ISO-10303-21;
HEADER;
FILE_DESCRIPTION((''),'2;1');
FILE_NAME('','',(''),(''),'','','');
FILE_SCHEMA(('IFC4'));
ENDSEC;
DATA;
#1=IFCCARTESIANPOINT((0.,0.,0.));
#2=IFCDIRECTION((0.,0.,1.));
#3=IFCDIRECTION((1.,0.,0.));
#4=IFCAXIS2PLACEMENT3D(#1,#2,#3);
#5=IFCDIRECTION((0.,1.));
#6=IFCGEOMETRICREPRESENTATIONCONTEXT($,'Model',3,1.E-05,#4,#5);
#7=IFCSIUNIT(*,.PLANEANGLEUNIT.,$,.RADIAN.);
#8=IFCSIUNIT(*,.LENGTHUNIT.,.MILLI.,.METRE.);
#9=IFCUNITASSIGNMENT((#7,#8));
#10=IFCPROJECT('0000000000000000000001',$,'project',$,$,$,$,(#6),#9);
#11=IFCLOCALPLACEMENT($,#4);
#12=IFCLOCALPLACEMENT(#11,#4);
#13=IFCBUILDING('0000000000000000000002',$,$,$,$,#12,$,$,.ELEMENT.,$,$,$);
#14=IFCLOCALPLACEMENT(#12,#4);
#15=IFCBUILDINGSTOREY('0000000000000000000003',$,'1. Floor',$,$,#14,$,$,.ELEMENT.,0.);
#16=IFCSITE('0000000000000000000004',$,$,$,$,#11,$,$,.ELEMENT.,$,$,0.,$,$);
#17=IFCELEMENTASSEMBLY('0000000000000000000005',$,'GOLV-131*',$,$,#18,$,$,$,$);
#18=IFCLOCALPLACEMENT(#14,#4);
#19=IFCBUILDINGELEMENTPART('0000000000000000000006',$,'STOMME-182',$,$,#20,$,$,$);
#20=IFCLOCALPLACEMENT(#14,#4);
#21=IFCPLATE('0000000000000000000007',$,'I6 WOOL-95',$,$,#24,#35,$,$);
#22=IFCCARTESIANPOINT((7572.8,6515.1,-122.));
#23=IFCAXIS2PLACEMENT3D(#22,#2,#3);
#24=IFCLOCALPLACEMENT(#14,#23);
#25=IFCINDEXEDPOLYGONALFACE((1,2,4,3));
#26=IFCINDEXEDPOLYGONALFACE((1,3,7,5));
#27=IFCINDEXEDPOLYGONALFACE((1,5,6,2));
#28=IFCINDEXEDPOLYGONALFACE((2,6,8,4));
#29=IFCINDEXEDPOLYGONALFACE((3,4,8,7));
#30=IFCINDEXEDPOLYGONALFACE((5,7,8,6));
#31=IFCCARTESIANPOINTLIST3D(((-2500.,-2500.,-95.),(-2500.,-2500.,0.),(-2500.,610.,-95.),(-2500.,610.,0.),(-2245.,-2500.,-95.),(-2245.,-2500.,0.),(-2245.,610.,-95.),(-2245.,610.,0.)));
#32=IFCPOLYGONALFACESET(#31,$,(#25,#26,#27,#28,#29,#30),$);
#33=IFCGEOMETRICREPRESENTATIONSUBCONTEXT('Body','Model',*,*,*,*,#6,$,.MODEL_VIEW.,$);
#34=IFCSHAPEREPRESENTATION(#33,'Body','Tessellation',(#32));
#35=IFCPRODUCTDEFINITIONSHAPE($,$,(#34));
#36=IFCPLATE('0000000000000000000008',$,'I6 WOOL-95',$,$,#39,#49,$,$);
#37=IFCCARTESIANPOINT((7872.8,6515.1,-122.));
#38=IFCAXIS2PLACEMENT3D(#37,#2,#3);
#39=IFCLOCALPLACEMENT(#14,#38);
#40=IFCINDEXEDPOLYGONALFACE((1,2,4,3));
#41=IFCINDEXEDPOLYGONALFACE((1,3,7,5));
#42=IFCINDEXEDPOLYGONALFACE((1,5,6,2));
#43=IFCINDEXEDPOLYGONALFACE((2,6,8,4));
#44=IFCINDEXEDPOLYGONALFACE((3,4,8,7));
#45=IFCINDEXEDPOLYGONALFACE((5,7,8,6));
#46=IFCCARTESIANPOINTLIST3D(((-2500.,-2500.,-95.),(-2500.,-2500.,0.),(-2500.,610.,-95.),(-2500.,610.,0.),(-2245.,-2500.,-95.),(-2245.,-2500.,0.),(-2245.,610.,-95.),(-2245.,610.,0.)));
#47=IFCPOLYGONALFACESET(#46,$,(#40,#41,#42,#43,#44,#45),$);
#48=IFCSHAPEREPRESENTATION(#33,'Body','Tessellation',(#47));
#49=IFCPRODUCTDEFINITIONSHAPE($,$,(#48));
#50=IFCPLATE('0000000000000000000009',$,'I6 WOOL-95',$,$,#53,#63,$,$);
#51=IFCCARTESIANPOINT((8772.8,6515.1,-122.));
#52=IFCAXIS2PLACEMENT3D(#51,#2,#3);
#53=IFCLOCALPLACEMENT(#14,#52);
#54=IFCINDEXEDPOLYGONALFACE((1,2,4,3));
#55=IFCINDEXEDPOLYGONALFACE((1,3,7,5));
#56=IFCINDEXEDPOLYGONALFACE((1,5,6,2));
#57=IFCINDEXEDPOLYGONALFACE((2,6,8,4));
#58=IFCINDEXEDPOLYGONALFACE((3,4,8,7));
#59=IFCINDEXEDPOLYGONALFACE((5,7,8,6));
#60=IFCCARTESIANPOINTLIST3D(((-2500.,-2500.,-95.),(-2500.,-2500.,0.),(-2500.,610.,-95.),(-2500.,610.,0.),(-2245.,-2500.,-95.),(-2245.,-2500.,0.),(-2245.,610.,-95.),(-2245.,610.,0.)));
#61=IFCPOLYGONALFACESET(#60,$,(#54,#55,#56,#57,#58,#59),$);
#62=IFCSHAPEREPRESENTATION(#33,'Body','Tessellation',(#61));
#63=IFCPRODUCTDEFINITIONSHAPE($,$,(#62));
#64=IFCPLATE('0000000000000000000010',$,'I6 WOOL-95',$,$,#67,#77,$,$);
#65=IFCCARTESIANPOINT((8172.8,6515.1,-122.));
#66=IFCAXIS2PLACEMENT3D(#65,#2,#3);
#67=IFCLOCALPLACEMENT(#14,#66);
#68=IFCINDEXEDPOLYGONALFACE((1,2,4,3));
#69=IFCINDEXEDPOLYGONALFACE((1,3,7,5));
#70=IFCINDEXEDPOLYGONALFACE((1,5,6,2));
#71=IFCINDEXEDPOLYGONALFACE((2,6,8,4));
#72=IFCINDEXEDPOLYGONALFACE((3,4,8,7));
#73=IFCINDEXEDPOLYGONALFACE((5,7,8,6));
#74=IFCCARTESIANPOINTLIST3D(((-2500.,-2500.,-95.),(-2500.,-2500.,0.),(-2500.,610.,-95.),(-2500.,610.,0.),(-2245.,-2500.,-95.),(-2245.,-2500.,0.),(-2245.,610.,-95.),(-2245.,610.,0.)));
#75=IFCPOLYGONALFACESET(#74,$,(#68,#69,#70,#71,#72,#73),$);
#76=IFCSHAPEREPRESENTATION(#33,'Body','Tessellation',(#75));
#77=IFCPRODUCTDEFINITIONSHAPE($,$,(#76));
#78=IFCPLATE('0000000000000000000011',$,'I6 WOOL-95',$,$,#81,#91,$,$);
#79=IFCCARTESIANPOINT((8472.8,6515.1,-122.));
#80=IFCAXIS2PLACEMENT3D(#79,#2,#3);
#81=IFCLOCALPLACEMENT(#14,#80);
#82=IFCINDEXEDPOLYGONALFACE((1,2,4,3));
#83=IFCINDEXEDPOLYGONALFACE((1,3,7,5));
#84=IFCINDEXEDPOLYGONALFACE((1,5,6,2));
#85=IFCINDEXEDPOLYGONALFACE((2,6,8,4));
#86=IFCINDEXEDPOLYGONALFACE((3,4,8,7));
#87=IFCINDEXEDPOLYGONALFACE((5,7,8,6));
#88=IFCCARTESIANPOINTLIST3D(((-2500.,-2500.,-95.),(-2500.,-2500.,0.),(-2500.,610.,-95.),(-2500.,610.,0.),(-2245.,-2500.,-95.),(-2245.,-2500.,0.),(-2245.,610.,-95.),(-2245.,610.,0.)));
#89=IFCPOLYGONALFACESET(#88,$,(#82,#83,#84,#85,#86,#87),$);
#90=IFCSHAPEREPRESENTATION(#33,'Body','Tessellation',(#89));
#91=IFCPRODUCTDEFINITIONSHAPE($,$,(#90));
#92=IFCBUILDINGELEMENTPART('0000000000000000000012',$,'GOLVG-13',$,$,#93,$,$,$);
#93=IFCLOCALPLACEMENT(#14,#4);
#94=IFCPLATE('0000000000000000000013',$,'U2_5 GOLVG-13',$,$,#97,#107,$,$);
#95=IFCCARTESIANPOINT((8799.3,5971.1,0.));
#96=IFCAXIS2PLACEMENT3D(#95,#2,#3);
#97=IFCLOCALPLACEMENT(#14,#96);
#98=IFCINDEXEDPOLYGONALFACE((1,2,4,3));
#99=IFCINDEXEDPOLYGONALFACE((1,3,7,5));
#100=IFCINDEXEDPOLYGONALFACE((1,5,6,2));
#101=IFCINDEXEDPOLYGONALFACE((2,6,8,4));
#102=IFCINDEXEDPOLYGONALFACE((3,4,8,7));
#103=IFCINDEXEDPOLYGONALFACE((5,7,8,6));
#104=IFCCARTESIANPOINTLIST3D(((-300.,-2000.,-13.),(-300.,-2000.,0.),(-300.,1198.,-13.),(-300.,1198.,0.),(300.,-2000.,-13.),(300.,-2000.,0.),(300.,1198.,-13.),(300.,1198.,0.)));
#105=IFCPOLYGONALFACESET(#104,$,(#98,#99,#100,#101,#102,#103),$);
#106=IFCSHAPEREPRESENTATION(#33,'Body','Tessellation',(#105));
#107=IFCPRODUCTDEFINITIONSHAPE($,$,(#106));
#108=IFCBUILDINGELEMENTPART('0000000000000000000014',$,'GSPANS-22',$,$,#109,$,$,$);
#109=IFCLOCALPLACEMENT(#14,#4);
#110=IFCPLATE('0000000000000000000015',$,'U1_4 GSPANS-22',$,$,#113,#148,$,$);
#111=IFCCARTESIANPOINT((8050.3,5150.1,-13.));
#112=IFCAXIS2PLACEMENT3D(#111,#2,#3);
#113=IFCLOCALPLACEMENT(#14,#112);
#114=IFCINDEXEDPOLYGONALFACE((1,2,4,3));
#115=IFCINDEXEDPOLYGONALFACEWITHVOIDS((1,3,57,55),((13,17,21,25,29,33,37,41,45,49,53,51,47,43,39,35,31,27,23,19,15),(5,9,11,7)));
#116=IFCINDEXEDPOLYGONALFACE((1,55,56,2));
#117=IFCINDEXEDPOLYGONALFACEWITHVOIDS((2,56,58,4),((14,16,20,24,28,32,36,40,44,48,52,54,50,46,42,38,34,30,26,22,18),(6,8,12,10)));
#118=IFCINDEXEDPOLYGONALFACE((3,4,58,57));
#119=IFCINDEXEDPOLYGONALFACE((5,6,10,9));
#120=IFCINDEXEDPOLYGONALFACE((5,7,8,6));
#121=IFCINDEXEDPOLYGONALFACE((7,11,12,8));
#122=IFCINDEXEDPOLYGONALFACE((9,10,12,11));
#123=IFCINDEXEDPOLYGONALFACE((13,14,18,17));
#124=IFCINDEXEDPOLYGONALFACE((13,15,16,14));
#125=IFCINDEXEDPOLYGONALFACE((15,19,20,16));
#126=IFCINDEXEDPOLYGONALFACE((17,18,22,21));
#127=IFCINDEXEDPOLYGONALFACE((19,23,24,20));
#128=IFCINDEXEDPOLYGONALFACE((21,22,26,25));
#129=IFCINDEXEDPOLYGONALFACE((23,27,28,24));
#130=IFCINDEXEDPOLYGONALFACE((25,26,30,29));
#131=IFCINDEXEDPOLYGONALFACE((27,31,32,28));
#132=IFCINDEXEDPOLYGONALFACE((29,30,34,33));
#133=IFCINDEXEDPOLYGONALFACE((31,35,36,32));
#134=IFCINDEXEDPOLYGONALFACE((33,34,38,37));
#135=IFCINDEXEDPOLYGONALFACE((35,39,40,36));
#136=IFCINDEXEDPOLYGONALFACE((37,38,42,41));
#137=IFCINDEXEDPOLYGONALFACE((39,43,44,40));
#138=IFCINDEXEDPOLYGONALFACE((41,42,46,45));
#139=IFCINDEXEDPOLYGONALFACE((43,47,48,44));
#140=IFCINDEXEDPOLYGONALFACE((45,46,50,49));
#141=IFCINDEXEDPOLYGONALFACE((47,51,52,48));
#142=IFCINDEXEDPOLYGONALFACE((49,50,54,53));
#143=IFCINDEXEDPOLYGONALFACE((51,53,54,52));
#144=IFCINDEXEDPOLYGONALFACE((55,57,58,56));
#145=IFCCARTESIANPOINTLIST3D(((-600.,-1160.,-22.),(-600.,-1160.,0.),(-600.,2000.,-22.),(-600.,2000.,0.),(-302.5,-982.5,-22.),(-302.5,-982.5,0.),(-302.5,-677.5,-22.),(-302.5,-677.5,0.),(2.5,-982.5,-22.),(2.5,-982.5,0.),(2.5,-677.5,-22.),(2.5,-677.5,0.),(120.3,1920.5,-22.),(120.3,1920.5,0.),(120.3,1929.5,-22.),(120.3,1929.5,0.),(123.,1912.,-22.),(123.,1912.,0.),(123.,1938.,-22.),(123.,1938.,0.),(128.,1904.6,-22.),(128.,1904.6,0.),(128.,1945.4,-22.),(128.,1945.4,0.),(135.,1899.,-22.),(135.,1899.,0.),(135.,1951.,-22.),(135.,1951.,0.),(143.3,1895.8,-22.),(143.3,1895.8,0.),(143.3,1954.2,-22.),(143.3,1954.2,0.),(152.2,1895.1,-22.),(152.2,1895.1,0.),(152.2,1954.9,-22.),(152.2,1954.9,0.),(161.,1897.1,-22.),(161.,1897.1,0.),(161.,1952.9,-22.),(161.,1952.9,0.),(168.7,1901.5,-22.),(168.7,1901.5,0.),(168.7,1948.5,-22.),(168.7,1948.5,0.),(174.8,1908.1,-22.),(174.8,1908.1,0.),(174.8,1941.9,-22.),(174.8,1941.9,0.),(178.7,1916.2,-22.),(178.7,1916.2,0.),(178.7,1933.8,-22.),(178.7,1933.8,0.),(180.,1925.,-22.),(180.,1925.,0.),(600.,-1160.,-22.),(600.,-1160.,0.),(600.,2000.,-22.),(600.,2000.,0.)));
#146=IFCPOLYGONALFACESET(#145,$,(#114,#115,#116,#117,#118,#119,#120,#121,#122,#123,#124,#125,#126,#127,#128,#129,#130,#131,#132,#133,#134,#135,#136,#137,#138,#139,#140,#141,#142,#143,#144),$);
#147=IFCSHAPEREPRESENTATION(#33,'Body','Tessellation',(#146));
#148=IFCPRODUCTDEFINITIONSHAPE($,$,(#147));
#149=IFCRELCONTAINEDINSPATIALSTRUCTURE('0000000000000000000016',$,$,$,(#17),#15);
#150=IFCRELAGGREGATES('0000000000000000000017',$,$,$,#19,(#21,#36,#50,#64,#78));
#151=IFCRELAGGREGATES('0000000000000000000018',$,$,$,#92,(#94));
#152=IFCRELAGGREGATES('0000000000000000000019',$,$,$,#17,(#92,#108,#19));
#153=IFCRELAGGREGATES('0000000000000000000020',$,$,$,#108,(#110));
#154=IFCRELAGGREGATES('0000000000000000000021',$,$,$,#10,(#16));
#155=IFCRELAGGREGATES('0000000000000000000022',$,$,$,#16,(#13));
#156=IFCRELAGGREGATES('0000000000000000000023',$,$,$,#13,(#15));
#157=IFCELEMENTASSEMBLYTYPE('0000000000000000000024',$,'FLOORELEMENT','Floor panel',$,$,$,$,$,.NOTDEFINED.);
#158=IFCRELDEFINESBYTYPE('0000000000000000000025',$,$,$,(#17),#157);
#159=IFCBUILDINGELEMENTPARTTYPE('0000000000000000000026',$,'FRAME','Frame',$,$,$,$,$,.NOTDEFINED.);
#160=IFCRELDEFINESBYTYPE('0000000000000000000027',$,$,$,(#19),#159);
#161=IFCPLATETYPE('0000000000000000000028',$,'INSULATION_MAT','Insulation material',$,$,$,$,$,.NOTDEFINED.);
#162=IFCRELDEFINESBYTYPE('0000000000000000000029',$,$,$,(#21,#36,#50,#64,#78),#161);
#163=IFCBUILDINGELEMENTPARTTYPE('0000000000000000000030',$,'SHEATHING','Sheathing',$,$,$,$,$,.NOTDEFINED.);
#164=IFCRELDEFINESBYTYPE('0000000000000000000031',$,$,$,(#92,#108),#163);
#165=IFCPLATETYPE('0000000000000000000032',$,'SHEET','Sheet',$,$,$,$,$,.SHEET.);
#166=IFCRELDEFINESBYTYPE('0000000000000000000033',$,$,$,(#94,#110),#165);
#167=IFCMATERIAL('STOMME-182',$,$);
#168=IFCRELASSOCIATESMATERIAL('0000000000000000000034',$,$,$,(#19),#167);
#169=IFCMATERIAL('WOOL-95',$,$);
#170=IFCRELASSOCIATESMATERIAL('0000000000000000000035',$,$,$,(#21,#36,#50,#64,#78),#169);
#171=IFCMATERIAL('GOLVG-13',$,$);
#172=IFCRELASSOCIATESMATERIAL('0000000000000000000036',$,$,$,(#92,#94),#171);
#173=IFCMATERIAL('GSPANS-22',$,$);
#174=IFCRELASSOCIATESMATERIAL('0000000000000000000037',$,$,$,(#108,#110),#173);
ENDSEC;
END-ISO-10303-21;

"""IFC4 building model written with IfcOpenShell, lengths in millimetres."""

from ifc_helpers import new_model, si_unit, direction, frame, origin_with_axes, origin_2d_with_axis, place, context, subcontext, project, spatial, rectangle, circle, extrude, boolean, material, type_object, element, aggregate, save


model = new_model("IFC4")

# Units and contexts
model_context = context("Model", 3, precision=1e-05, world=origin_with_axes(), true_north=direction((0.0, 1.0)))
body_context = subcontext(model_context, "Body", "Model", "MODEL_VIEW")
ifc_project = project(units=[si_unit("PLANEANGLEUNIT", "RADIAN"), si_unit("LENGTHUNIT", "METRE", prefix="MILLI")], contexts=[model_context])

# Site, building, storey
site_placement = place(None, origin_with_axes())
site = spatial("IfcSite", under=ifc_project, at=site_placement, CompositionType="ELEMENT", RefElevation=0.0)
building_placement = place(site_placement, origin_with_axes())
building = spatial("IfcBuilding", under=site, at=building_placement, CompositionType="ELEMENT")
storey_placement = place(building_placement, origin_with_axes())
storey = spatial("IfcBuildingStorey", under=building, at=storey_placement, Name="1. Floor", CompositionType="ELEMENT", Elevation=0.0)

# Element assembly, building element part, plates
element_assembly_type_1 = type_object("IfcElementAssemblyType", Name="FLOORELEMENT", Description="Floor panel", PredefinedType="NOTDEFINED")
assembly_1_placement = place(storey_placement, origin_with_axes())
assembly_1 = element("IfcElementAssembly", 1, at=assembly_1_placement, inside=storey, type_object=element_assembly_type_1, Name="GOLV-131*")
ifc_material_1 = material(Name="STOMME-182")
building_element_part_type_1 = type_object("IfcBuildingElementPartType", Name="FRAME", Description="Frame", PredefinedType="NOTDEFINED")
building_element_part_1_placement = place(storey_placement, origin_with_axes())
building_element_part_1 = element("IfcBuildingElementPart", 2, at=building_element_part_1_placement, type_object=building_element_part_type_1, material=ifc_material_1, Name="STOMME-182")
ifc_material_2 = material(Name="WOOL-95")
plate_type_1 = type_object("IfcPlateType", Name="INSULATION_MAT", Description="Insulation material", PredefinedType="NOTDEFINED")
plate_1_placement = place(storey_placement, frame((7572.8, 6515.1, -122.0), z_axis=(0.0, 0.0, 1.0), x_axis=(1.0, 0.0, 0.0)))
plate_1 = element("IfcPlate", 3, at=plate_1_placement, type_object=plate_type_1, material=ifc_material_2, Name="I6 WOOL-95", context=body_context, shape_type="SweptSolid", body=[
    extrude(rectangle(XDim=95.0, YDim=255.0, at=origin_2d_with_axis()), frame((-2372.5, -2500.0, -47.5), z_axis=(0.0, 1.0, 0.0), x_axis=(0.0, 0.0, 1.0)), (0.0, 0.0, 1.0), 3110.0),
])
plate_2_placement = place(storey_placement, frame((7872.8, 6515.1, -122.0), z_axis=(0.0, 0.0, 1.0), x_axis=(1.0, 0.0, 0.0)))
plate_2 = element("IfcPlate", 4, at=plate_2_placement, type_object=plate_type_1, material=ifc_material_2, Name="I6 WOOL-95", context=body_context, shape_type="SweptSolid", body=[
    extrude(rectangle(XDim=95.0, YDim=255.0, at=origin_2d_with_axis()), frame((-2372.5, -2500.0, -47.5), z_axis=(0.0, 1.0, 0.0), x_axis=(0.0, 0.0, 1.0)), (0.0, 0.0, 1.0), 3110.0),
])
plate_3_placement = place(storey_placement, frame((8772.8, 6515.1, -122.0), z_axis=(0.0, 0.0, 1.0), x_axis=(1.0, 0.0, 0.0)))
plate_3 = element("IfcPlate", 5, at=plate_3_placement, type_object=plate_type_1, material=ifc_material_2, Name="I6 WOOL-95", context=body_context, shape_type="SweptSolid", body=[
    extrude(rectangle(XDim=95.0, YDim=255.0, at=origin_2d_with_axis()), frame((-2372.5, -2500.0, -47.5), z_axis=(0.0, 1.0, 0.0), x_axis=(0.0, 0.0, 1.0)), (0.0, 0.0, 1.0), 3110.0),
])
plate_4_placement = place(storey_placement, frame((8172.8, 6515.1, -122.0), z_axis=(0.0, 0.0, 1.0), x_axis=(1.0, 0.0, 0.0)))
plate_4 = element("IfcPlate", 6, at=plate_4_placement, type_object=plate_type_1, material=ifc_material_2, Name="I6 WOOL-95", context=body_context, shape_type="SweptSolid", body=[
    extrude(rectangle(XDim=95.0, YDim=255.0, at=origin_2d_with_axis()), frame((-2372.5, -2500.0, -47.5), z_axis=(0.0, 1.0, 0.0), x_axis=(0.0, 0.0, 1.0)), (0.0, 0.0, 1.0), 3110.0),
])
plate_5_placement = place(storey_placement, frame((8472.8, 6515.1, -122.0), z_axis=(0.0, 0.0, 1.0), x_axis=(1.0, 0.0, 0.0)))
plate_5 = element("IfcPlate", 7, at=plate_5_placement, type_object=plate_type_1, material=ifc_material_2, Name="I6 WOOL-95", context=body_context, shape_type="SweptSolid", body=[
    extrude(rectangle(XDim=95.0, YDim=255.0, at=origin_2d_with_axis()), frame((-2372.5, -2500.0, -47.5), z_axis=(0.0, 1.0, 0.0), x_axis=(0.0, 0.0, 1.0)), (0.0, 0.0, 1.0), 3110.0),
])
aggregate(building_element_part_1, [plate_1, plate_2, plate_3, plate_4, plate_5])

# Building element part, plate
ifc_material_3 = material(Name="GOLVG-13")
building_element_part_type_2 = type_object("IfcBuildingElementPartType", Name="SHEATHING", Description="Sheathing", PredefinedType="NOTDEFINED")
building_element_part_2_placement = place(storey_placement, origin_with_axes())
building_element_part_2 = element("IfcBuildingElementPart", 8, at=building_element_part_2_placement, type_object=building_element_part_type_2, material=ifc_material_3, Name="GOLVG-13")
plate_type_2 = type_object("IfcPlateType", Name="SHEET", Description="Sheet", PredefinedType="SHEET")
plate_6_placement = place(storey_placement, frame((8799.3, 5971.1, 0.0), z_axis=(0.0, 0.0, 1.0), x_axis=(1.0, 0.0, 0.0)))
plate_6 = element("IfcPlate", 9, at=plate_6_placement, type_object=plate_type_2, material=ifc_material_3, Name="U2_5 GOLVG-13", context=body_context, shape_type="SweptSolid", body=[
    extrude(rectangle(XDim=13.0, YDim=600.0, at=origin_2d_with_axis()), frame((0.0, -2000.0, -6.5), z_axis=(0.0, 1.0, 0.0), x_axis=(0.0, 0.0, 1.0)), (0.0, 0.0, 1.0), 3198.0),
])
aggregate(building_element_part_2, [plate_6])

# Building element part
ifc_material_4 = material(Name="GSPANS-22")
building_element_part_3_placement = place(storey_placement, origin_with_axes())
building_element_part_3 = element("IfcBuildingElementPart", 10, at=building_element_part_3_placement, type_object=building_element_part_type_2, material=ifc_material_4, Name="GSPANS-22")
aggregate(assembly_1, [building_element_part_2, building_element_part_3, building_element_part_1])

# Plate
plate_7_placement = place(storey_placement, frame((8050.3, 5150.1, -13.0), z_axis=(0.0, 0.0, 1.0), x_axis=(1.0, 0.0, 0.0)))
solid = boolean("DIFFERENCE", boolean("DIFFERENCE", boolean("DIFFERENCE", boolean("DIFFERENCE", boolean("DIFFERENCE", boolean("DIFFERENCE", boolean("DIFFERENCE", boolean("DIFFERENCE", extrude(rectangle(XDim=22.0, YDim=1200.0, at=origin_2d_with_axis()), frame((0.0, -1160.0, -11.0), z_axis=(0.0, 1.0, 0.0), x_axis=(0.0, 0.0, 1.0)), (0.0, 0.0, 1.0), 3160.0), extrude(rectangle(XDim=305.0, YDim=305.0, at=origin_2d_with_axis()), frame((-150.0, -830.0, 0.0), z_axis=(0.0, 0.0, 1.0), x_axis=(1.0, 0.0, 0.0)), (0.0, 0.0, -1.0), 35.0)), extrude(circle(Radius=30.0, at=origin_2d_with_axis()), frame((150.0, 1925.0, 76.0), z_axis=(0.0, 0.0, 1.0), x_axis=(1.0, 0.0, 0.0)), (0.0, 0.0, -1.0), 100.0)), extrude(circle(Radius=80.0, at=origin_2d_with_axis()), frame((-150.0, -830.0, 76.0), z_axis=(0.0, 0.0, 1.0), x_axis=(1.0, 0.0, 0.0)), (0.0, 0.0, -1.0), 100.0)), extrude(rectangle(XDim=305.0, YDim=305.0, at=origin_2d_with_axis()), frame((-150.0, -830.0, 0.0), z_axis=(0.0, 0.0, 1.0), x_axis=(1.0, 0.0, 0.0)), (0.0, 0.0, -1.0), 35.0)), extrude(circle(Radius=30.0, at=origin_2d_with_axis()), frame((150.0, 1925.0, 76.0), z_axis=(0.0, 0.0, 1.0), x_axis=(1.0, 0.0, 0.0)), (0.0, 0.0, -1.0), 100.0)), extrude(circle(Radius=80.0, at=origin_2d_with_axis()), frame((-150.0, -830.0, 76.0), z_axis=(0.0, 0.0, 1.0), x_axis=(1.0, 0.0, 0.0)), (0.0, 0.0, -1.0), 100.0)), extrude(rectangle(XDim=305.0, YDim=305.0, at=origin_2d_with_axis()), frame((-150.0, -830.0, 0.0), z_axis=(0.0, 0.0, 1.0), x_axis=(1.0, 0.0, 0.0)), (0.0, 0.0, -1.0), 35.0)), extrude(circle(Radius=30.0, at=origin_2d_with_axis()), frame((150.0, 1925.0, 76.0), z_axis=(0.0, 0.0, 1.0), x_axis=(1.0, 0.0, 0.0)), (0.0, 0.0, -1.0), 100.0))
plate_7 = element("IfcPlate", 11, at=plate_7_placement, type_object=plate_type_2, material=ifc_material_4, Name="U1_4 GSPANS-22", context=body_context, shape_type="CSG", body=[
    boolean("DIFFERENCE", boolean("DIFFERENCE", boolean("DIFFERENCE", boolean("DIFFERENCE", boolean("DIFFERENCE", boolean("DIFFERENCE", boolean("DIFFERENCE", solid, extrude(circle(Radius=80.0, at=origin_2d_with_axis()), frame((-150.0, -830.0, 76.0), z_axis=(0.0, 0.0, 1.0), x_axis=(1.0, 0.0, 0.0)), (0.0, 0.0, -1.0), 100.0)), extrude(rectangle(XDim=305.0, YDim=305.0, at=origin_2d_with_axis()), frame((-150.0, -830.0, 0.0), z_axis=(0.0, 0.0, 1.0), x_axis=(1.0, 0.0, 0.0)), (0.0, 0.0, -1.0), 35.0)), extrude(circle(Radius=30.0, at=origin_2d_with_axis()), frame((150.0, 1925.0, 76.0), z_axis=(0.0, 0.0, 1.0), x_axis=(1.0, 0.0, 0.0)), (0.0, 0.0, -1.0), 100.0)), extrude(circle(Radius=80.0, at=origin_2d_with_axis()), frame((-150.0, -830.0, 76.0), z_axis=(0.0, 0.0, 1.0), x_axis=(1.0, 0.0, 0.0)), (0.0, 0.0, -1.0), 100.0)), extrude(rectangle(XDim=305.0, YDim=305.0, at=origin_2d_with_axis()), frame((-150.0, -830.0, 0.0), z_axis=(0.0, 0.0, 1.0), x_axis=(1.0, 0.0, 0.0)), (0.0, 0.0, -1.0), 35.0)), extrude(circle(Radius=30.0, at=origin_2d_with_axis()), frame((150.0, 1925.0, 76.0), z_axis=(0.0, 0.0, 1.0), x_axis=(1.0, 0.0, 0.0)), (0.0, 0.0, -1.0), 100.0)), extrude(circle(Radius=80.0, at=origin_2d_with_axis()), frame((-150.0, -830.0, 76.0), z_axis=(0.0, 0.0, 1.0), x_axis=(1.0, 0.0, 0.0)), (0.0, 0.0, -1.0), 100.0)),
])
aggregate(building_element_part_3, [plate_7])

save(model, "model.ifc")
